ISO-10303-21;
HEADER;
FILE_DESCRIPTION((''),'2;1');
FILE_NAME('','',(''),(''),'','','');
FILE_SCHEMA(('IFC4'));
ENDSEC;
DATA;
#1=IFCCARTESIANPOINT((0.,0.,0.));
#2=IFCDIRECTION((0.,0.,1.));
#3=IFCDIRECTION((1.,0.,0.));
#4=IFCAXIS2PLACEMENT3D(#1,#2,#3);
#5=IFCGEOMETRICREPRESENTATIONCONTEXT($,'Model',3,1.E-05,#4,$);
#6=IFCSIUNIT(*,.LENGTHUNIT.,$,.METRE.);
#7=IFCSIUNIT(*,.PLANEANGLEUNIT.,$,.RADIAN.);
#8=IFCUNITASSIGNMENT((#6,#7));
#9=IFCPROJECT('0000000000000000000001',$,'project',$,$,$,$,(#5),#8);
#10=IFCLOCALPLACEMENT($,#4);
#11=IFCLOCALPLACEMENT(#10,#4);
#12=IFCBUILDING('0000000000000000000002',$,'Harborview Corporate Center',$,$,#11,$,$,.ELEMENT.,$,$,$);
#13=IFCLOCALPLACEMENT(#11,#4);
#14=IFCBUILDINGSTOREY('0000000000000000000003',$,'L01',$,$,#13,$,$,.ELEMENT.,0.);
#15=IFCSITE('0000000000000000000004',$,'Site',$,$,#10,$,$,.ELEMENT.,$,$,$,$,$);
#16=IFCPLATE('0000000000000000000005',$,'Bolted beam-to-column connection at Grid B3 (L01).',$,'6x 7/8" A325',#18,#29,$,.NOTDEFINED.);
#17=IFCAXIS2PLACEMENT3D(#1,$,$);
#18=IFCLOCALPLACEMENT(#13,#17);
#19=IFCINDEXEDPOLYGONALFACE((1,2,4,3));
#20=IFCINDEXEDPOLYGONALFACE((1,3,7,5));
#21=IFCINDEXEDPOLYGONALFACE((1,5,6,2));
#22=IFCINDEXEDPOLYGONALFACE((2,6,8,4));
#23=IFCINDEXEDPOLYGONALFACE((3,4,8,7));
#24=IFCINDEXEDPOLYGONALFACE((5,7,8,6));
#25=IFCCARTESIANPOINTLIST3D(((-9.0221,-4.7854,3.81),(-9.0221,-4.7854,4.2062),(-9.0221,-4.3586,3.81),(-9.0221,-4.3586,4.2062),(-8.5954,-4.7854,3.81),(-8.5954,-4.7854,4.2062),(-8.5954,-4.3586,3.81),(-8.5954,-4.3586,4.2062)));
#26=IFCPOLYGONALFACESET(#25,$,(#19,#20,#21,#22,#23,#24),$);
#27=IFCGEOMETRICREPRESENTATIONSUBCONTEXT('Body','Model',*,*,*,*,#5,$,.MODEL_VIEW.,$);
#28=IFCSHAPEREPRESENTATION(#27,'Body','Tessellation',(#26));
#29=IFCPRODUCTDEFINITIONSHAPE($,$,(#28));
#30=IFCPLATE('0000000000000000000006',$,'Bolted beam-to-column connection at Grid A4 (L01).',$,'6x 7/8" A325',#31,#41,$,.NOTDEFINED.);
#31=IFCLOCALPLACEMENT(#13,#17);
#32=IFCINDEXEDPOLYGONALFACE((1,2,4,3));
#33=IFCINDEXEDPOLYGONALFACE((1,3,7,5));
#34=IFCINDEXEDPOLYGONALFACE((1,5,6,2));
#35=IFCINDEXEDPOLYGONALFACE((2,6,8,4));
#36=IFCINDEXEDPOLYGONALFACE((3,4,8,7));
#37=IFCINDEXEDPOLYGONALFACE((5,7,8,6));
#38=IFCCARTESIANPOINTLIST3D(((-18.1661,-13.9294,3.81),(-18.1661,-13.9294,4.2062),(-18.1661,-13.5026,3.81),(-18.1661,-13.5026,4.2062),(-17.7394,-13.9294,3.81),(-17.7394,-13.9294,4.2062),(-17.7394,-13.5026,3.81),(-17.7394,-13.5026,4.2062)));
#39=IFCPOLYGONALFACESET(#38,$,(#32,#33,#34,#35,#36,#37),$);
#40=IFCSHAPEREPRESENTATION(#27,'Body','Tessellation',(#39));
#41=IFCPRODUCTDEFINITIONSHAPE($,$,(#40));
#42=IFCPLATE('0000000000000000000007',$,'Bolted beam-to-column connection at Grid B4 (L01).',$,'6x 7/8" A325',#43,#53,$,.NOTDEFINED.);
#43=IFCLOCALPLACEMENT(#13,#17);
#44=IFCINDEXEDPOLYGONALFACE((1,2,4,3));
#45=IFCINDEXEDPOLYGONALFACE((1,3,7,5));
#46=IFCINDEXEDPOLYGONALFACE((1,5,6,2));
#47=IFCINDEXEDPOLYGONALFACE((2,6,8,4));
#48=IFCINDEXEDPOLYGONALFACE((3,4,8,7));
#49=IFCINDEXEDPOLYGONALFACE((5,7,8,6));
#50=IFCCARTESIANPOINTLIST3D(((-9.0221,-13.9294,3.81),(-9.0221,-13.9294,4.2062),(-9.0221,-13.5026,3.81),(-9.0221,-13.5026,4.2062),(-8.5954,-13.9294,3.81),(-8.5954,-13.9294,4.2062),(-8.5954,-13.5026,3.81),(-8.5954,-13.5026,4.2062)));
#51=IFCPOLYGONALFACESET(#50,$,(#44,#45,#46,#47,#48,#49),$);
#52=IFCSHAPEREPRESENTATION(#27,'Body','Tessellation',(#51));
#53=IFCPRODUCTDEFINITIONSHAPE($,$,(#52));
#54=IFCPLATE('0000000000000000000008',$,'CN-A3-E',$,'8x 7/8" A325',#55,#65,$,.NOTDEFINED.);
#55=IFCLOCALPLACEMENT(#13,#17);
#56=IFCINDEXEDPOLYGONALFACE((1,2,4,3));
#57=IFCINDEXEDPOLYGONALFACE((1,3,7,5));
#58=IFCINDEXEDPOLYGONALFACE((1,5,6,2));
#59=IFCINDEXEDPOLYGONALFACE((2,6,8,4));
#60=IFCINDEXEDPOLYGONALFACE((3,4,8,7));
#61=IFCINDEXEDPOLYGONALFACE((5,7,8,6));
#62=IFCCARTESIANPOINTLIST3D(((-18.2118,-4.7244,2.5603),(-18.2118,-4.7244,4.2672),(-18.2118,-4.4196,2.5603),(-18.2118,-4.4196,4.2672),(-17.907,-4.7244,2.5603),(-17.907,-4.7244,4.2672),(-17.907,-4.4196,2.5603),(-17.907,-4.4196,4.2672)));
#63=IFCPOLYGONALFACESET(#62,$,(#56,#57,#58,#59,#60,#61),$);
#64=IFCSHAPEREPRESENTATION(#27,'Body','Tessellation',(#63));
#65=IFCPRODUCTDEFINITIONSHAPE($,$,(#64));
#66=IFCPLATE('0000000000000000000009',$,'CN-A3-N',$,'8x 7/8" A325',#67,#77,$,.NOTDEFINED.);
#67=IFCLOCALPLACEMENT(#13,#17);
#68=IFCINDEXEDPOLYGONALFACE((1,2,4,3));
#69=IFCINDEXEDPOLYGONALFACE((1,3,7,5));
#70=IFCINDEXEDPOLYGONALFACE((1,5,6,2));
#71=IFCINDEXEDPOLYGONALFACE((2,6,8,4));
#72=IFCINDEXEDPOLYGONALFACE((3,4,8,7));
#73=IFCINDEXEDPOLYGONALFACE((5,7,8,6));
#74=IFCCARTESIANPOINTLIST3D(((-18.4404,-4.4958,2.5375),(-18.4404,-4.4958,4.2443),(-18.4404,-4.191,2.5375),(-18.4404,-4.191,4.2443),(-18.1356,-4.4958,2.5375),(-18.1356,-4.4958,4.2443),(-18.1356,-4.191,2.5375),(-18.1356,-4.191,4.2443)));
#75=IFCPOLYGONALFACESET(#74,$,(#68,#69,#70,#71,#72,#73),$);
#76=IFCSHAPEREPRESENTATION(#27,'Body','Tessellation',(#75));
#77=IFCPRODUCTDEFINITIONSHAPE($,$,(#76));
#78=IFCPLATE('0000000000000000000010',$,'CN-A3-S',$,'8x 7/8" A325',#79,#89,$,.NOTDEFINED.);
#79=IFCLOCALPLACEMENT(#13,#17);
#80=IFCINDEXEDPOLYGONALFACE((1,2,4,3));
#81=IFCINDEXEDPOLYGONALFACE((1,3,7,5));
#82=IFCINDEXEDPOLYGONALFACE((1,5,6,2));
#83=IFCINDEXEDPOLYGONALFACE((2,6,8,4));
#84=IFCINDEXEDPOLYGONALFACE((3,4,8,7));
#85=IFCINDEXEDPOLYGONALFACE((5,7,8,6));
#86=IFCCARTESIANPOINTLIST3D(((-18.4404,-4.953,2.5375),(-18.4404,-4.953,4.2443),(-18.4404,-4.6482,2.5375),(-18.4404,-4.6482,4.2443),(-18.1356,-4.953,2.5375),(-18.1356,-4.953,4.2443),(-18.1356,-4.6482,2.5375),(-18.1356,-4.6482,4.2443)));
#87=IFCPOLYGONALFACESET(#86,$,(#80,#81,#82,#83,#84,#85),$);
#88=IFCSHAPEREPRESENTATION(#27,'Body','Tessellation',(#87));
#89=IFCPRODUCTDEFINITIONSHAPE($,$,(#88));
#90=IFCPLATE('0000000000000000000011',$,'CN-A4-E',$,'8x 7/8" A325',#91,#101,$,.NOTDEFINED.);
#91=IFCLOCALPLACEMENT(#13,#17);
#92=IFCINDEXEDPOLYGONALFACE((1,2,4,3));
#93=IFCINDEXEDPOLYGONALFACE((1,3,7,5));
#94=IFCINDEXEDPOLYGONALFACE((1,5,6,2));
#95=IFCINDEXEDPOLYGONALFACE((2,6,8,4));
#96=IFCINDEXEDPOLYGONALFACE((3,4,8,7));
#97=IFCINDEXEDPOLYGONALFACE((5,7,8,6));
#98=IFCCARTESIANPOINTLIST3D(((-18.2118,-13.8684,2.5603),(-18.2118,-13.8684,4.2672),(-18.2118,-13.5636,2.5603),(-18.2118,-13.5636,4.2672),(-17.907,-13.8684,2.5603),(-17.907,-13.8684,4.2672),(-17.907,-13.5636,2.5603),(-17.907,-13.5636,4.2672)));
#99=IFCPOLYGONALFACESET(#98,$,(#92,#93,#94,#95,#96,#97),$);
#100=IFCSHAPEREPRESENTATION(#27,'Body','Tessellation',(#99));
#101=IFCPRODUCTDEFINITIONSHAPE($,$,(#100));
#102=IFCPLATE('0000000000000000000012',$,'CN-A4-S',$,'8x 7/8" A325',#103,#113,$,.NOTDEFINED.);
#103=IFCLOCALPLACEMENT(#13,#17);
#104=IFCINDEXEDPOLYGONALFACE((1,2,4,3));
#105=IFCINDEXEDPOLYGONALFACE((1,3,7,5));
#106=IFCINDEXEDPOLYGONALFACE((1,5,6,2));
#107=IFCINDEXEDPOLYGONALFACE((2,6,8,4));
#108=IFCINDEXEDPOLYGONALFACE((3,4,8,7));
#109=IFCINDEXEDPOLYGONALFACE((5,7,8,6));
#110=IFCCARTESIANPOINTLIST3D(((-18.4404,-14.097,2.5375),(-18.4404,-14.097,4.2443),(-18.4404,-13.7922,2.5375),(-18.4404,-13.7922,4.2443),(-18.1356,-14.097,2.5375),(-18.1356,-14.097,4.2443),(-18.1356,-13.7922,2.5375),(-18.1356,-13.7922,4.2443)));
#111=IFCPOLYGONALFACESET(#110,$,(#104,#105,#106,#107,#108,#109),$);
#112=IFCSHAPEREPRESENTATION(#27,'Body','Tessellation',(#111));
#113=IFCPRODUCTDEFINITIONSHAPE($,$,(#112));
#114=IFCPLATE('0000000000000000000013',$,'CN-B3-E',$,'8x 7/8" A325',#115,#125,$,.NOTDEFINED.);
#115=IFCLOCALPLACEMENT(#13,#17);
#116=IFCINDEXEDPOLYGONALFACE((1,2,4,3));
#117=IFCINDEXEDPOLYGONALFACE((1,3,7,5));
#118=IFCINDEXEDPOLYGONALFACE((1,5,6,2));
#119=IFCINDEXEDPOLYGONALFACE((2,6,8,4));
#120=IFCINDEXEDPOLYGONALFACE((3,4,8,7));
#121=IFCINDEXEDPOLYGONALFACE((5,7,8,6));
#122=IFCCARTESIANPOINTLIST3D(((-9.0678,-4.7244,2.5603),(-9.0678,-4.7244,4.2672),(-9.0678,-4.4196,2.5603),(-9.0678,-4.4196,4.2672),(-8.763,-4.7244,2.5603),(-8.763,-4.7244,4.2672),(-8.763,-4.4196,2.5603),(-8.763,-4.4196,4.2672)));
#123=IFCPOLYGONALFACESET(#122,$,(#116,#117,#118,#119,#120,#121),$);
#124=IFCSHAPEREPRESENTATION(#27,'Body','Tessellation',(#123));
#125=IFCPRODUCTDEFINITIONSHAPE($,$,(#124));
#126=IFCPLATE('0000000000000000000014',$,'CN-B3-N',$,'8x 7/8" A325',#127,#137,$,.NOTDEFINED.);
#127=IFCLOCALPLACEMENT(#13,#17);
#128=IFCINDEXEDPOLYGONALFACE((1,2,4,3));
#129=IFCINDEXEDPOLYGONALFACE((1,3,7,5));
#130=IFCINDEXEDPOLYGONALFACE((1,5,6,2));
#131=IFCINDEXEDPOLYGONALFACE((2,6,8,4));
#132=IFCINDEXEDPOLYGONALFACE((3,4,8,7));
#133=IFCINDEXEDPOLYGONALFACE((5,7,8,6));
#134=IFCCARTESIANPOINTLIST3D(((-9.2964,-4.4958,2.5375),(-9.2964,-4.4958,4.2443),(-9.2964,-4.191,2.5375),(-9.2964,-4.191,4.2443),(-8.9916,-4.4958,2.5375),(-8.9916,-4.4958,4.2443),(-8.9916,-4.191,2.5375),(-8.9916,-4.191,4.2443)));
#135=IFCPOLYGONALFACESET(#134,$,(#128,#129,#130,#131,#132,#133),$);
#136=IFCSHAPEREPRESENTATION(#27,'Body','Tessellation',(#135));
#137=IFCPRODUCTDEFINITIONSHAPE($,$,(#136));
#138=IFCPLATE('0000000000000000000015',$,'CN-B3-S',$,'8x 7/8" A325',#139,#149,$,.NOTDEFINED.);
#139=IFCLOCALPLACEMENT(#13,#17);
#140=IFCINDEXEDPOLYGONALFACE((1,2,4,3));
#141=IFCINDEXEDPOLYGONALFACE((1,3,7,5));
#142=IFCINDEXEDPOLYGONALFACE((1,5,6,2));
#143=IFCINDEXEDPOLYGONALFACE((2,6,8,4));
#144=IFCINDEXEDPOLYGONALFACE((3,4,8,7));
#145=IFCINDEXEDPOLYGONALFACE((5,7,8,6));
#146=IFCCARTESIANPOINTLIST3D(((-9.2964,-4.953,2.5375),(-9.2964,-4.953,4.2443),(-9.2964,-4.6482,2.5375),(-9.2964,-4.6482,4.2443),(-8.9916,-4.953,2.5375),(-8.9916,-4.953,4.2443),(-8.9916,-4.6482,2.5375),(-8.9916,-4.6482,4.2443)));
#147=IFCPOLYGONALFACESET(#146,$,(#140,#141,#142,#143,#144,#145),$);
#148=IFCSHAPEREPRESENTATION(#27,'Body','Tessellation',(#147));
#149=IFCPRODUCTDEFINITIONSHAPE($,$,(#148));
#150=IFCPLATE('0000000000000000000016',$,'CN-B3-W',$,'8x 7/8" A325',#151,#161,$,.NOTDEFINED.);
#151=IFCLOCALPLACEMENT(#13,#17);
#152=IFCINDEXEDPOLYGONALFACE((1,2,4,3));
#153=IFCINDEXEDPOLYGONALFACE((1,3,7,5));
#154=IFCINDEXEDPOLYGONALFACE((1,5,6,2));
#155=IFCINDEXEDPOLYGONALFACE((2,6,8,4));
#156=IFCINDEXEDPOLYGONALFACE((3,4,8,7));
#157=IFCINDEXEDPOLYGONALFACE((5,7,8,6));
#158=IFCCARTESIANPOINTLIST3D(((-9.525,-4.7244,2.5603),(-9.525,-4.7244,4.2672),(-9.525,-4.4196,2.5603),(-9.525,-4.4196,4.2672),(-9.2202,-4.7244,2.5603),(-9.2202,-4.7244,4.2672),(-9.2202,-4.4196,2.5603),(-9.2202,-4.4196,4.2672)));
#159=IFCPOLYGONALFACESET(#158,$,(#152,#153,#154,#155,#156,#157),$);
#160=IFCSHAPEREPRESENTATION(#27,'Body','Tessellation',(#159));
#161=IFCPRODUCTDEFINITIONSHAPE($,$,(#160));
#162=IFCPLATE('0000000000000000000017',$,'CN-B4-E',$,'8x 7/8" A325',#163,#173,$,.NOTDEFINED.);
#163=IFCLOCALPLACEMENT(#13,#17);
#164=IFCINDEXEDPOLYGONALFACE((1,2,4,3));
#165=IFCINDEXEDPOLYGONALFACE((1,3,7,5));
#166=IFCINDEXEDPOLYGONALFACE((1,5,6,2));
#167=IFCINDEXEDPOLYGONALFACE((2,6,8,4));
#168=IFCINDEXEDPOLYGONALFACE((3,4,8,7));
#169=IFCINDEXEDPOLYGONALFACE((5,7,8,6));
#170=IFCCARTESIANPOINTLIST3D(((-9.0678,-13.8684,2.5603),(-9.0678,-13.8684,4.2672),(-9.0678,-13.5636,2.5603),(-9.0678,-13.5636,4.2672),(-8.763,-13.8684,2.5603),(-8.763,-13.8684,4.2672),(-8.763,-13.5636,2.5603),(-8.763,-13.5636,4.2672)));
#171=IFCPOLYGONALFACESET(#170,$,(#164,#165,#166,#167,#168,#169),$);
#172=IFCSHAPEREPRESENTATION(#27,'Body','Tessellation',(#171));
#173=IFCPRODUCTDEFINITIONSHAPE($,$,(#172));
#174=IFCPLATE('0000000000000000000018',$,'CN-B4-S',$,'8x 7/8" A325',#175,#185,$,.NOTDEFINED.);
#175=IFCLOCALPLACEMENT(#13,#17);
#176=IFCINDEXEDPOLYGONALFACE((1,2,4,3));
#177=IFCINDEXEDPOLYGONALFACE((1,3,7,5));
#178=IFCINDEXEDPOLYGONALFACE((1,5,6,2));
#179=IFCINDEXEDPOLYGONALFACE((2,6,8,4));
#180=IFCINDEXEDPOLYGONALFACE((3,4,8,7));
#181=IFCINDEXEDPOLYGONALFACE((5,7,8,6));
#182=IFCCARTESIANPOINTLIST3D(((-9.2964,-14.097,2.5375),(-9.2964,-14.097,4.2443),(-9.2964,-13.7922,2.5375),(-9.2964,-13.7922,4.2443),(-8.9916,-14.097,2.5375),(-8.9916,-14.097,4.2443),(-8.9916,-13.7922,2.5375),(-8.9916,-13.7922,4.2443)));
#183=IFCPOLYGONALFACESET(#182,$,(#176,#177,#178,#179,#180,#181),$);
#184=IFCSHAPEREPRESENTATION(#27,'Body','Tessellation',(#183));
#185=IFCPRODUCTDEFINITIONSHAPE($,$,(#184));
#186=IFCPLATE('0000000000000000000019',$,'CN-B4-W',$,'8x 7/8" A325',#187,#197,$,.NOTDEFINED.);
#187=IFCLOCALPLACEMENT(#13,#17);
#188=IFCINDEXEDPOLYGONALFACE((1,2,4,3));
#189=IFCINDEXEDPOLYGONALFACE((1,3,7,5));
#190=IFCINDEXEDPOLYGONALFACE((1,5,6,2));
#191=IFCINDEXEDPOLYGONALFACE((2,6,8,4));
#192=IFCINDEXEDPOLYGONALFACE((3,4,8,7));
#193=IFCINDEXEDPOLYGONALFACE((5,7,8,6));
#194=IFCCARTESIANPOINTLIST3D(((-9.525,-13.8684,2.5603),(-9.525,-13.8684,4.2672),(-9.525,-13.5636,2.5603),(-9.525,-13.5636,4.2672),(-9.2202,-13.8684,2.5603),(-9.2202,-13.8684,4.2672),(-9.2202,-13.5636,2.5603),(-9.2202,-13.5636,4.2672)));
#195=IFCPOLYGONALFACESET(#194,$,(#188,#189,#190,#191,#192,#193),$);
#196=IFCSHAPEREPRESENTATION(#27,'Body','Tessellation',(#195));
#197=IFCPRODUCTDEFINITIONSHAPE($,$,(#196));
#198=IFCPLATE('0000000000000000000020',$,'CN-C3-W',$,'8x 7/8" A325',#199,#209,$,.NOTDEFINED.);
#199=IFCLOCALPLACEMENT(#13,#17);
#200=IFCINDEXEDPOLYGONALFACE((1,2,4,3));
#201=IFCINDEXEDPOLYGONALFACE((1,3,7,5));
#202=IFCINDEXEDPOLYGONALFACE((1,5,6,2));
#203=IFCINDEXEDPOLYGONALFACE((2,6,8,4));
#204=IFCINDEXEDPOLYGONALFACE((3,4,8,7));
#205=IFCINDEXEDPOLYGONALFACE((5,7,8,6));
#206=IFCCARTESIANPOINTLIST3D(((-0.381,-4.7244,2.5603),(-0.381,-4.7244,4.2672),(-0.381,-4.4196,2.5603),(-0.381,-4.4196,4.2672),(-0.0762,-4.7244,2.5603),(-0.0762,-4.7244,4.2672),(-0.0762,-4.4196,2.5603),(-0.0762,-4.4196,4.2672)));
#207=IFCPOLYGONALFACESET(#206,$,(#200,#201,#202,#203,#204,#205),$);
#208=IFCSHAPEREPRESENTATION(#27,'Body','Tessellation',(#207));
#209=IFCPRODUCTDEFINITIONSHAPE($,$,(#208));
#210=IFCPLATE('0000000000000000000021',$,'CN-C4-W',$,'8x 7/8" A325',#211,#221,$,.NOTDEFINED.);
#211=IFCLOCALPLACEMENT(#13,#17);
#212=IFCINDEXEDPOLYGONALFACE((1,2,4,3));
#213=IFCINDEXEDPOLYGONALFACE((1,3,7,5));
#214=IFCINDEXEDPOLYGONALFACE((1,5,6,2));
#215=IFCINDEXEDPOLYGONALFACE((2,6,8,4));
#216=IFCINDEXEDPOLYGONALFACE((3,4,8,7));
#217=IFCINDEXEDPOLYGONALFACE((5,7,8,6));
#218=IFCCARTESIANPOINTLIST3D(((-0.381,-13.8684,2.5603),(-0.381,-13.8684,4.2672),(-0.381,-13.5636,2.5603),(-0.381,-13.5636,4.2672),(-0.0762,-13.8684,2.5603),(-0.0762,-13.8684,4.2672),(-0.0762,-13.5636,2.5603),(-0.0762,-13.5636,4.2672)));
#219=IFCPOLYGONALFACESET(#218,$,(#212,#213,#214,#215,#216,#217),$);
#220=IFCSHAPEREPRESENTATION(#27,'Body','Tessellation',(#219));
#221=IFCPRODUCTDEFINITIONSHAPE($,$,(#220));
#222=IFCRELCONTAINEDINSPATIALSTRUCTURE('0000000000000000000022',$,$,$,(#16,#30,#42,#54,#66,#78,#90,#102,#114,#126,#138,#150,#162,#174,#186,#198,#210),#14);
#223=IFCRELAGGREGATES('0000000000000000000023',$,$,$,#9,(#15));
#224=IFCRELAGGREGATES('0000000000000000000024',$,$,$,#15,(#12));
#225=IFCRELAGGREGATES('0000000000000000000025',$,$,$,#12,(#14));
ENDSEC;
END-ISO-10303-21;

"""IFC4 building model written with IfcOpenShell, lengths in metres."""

from ifc_helpers import new_model, si_unit, frame, origin_with_axes, place, context, subcontext, project, spatial, rectangle, extrude, element, save


model = new_model("IFC4")

# Units and contexts
model_context = context("Model", 3, precision=1e-05, world=origin_with_axes())
body_context = subcontext(model_context, "Body", "Model", "MODEL_VIEW")
ifc_project = project(units=[si_unit("LENGTHUNIT", "METRE"), si_unit("PLANEANGLEUNIT", "RADIAN")], contexts=[model_context])

# Site, building, storey
site_placement = place(None, origin_with_axes())
site = spatial("IfcSite", under=ifc_project, at=site_placement, Name="Site", CompositionType="ELEMENT")
building_placement = place(site_placement, origin_with_axes())
building = spatial("IfcBuilding", under=site, at=building_placement, Name="Harborview Corporate Center", CompositionType="ELEMENT")
storey_placement = place(building_placement, origin_with_axes())
storey = spatial("IfcBuildingStorey", under=building, at=storey_placement, Name="L01", CompositionType="ELEMENT", Elevation=0.0)

# Plates
plate_1_placement = place(storey_placement, frame((-8.8087, -4.572, 3.81), z_axis=(0.0, 0.0, 1.0), x_axis=(1.0, 0.0, 0.0)))
element("IfcPlate", 1, at=plate_1_placement, inside=storey, Name="Bolted beam-to-column connection at Grid B3 (L01).", ObjectType="6x 7/8\" A325", PredefinedType="NOTDEFINED", context=body_context, shape_type="SweptSolid", body=[
    extrude(rectangle(XDim=0.4267, YDim=0.4267), origin_with_axes(), (0.0, 0.0, 1.0), 0.3962),
])
plate_2_placement = place(storey_placement, frame((-17.9527, -13.716, 3.81), z_axis=(0.0, 0.0, 1.0), x_axis=(1.0, 0.0, 0.0)))
element("IfcPlate", 2, at=plate_2_placement, inside=storey, Name="Bolted beam-to-column connection at Grid A4 (L01).", ObjectType="6x 7/8\" A325", PredefinedType="NOTDEFINED", context=body_context, shape_type="SweptSolid", body=[
    extrude(rectangle(XDim=0.4267, YDim=0.4267), origin_with_axes(), (0.0, 0.0, 1.0), 0.3962),
])
plate_3_placement = place(storey_placement, frame((-8.8087, -13.716, 3.81), z_axis=(0.0, 0.0, 1.0), x_axis=(1.0, 0.0, 0.0)))
element("IfcPlate", 3, at=plate_3_placement, inside=storey, Name="Bolted beam-to-column connection at Grid B4 (L01).", ObjectType="6x 7/8\" A325", PredefinedType="NOTDEFINED", context=body_context, shape_type="SweptSolid", body=[
    extrude(rectangle(XDim=0.4267, YDim=0.4267), origin_with_axes(), (0.0, 0.0, 1.0), 0.3962),
])
for number, where, z_axis, x_axis, name in (
    (4, (-18.0594, -4.572, 2.5603), (0.0, 0.0, 1.0), (1.0, 0.0, 0.0), "CN-A3-E"),
    (5, (-18.288, -4.3434, 2.5375), (0.0, 0.0, 1.0), (1.0, 0.0, 0.0), "CN-A3-N"),
    (6, (-18.288, -4.8006, 2.5375), (0.0, 0.0, 1.0), (1.0, 0.0, 0.0), "CN-A3-S"),
    (7, (-18.0594, -13.716, 2.5603), (0.0, 0.0, 1.0), (1.0, 0.0, 0.0), "CN-A4-E"),
    (8, (-18.288, -13.9446, 2.5375), (0.0, 0.0, 1.0), (1.0, 0.0, 0.0), "CN-A4-S"),
    (9, (-8.9154, -4.572, 2.5603), (0.0, 0.0, 1.0), (1.0, 0.0, 0.0), "CN-B3-E"),
    (10, (-9.144, -4.3434, 2.5375), (0.0, 0.0, 1.0), (1.0, 0.0, 0.0), "CN-B3-N"),
    (11, (-9.144, -4.8006, 2.5375), (0.0, 0.0, 1.0), (1.0, 0.0, 0.0), "CN-B3-S"),
    (12, (-9.3726, -4.572, 2.5603), (0.0, 0.0, 1.0), (1.0, 0.0, 0.0), "CN-B3-W"),
    (13, (-8.9154, -13.716, 2.5603), (0.0, 0.0, 1.0), (1.0, 0.0, 0.0), "CN-B4-E"),
    (14, (-9.144, -13.9446, 2.5375), (0.0, 0.0, 1.0), (1.0, 0.0, 0.0), "CN-B4-S"),
    (15, (-9.3726, -13.716, 2.5603), (0.0, 0.0, 1.0), (1.0, 0.0, 0.0), "CN-B4-W"),
):
    element("IfcPlate", number, at=place(storey_placement, frame(where, z_axis=z_axis, x_axis=x_axis)), inside=storey, Name=name, ObjectType="8x 7/8\" A325", PredefinedType="NOTDEFINED", context=body_context, shape_type="SweptSolid", body=[
        extrude(rectangle(XDim=0.3048, YDim=0.3048), origin_with_axes(), (0.0, 0.0, 1.0), 1.7069),
    ])
for number, where, z_axis, x_axis, name in (
    (16, (-0.2286, -4.572, 2.5603), (0.0, 0.0, 1.0), (1.0, 0.0, 0.0), "CN-C3-W"),
    (17, (-0.2286, -13.716, 2.5603), (0.0, 0.0, 1.0), (1.0, 0.0, 0.0), "CN-C4-W"),
):
    element("IfcPlate", number, at=place(storey_placement, frame(where, z_axis=z_axis, x_axis=x_axis)), inside=storey, Name=name, ObjectType="8x 7/8\" A325", PredefinedType="NOTDEFINED", context=body_context, shape_type="SweptSolid", body=[
        extrude(rectangle(XDim=0.3048, YDim=0.3048), origin_with_axes(), (0.0, 0.0, 1.0), 1.7069),
    ])

save(model, "model.ifc")
